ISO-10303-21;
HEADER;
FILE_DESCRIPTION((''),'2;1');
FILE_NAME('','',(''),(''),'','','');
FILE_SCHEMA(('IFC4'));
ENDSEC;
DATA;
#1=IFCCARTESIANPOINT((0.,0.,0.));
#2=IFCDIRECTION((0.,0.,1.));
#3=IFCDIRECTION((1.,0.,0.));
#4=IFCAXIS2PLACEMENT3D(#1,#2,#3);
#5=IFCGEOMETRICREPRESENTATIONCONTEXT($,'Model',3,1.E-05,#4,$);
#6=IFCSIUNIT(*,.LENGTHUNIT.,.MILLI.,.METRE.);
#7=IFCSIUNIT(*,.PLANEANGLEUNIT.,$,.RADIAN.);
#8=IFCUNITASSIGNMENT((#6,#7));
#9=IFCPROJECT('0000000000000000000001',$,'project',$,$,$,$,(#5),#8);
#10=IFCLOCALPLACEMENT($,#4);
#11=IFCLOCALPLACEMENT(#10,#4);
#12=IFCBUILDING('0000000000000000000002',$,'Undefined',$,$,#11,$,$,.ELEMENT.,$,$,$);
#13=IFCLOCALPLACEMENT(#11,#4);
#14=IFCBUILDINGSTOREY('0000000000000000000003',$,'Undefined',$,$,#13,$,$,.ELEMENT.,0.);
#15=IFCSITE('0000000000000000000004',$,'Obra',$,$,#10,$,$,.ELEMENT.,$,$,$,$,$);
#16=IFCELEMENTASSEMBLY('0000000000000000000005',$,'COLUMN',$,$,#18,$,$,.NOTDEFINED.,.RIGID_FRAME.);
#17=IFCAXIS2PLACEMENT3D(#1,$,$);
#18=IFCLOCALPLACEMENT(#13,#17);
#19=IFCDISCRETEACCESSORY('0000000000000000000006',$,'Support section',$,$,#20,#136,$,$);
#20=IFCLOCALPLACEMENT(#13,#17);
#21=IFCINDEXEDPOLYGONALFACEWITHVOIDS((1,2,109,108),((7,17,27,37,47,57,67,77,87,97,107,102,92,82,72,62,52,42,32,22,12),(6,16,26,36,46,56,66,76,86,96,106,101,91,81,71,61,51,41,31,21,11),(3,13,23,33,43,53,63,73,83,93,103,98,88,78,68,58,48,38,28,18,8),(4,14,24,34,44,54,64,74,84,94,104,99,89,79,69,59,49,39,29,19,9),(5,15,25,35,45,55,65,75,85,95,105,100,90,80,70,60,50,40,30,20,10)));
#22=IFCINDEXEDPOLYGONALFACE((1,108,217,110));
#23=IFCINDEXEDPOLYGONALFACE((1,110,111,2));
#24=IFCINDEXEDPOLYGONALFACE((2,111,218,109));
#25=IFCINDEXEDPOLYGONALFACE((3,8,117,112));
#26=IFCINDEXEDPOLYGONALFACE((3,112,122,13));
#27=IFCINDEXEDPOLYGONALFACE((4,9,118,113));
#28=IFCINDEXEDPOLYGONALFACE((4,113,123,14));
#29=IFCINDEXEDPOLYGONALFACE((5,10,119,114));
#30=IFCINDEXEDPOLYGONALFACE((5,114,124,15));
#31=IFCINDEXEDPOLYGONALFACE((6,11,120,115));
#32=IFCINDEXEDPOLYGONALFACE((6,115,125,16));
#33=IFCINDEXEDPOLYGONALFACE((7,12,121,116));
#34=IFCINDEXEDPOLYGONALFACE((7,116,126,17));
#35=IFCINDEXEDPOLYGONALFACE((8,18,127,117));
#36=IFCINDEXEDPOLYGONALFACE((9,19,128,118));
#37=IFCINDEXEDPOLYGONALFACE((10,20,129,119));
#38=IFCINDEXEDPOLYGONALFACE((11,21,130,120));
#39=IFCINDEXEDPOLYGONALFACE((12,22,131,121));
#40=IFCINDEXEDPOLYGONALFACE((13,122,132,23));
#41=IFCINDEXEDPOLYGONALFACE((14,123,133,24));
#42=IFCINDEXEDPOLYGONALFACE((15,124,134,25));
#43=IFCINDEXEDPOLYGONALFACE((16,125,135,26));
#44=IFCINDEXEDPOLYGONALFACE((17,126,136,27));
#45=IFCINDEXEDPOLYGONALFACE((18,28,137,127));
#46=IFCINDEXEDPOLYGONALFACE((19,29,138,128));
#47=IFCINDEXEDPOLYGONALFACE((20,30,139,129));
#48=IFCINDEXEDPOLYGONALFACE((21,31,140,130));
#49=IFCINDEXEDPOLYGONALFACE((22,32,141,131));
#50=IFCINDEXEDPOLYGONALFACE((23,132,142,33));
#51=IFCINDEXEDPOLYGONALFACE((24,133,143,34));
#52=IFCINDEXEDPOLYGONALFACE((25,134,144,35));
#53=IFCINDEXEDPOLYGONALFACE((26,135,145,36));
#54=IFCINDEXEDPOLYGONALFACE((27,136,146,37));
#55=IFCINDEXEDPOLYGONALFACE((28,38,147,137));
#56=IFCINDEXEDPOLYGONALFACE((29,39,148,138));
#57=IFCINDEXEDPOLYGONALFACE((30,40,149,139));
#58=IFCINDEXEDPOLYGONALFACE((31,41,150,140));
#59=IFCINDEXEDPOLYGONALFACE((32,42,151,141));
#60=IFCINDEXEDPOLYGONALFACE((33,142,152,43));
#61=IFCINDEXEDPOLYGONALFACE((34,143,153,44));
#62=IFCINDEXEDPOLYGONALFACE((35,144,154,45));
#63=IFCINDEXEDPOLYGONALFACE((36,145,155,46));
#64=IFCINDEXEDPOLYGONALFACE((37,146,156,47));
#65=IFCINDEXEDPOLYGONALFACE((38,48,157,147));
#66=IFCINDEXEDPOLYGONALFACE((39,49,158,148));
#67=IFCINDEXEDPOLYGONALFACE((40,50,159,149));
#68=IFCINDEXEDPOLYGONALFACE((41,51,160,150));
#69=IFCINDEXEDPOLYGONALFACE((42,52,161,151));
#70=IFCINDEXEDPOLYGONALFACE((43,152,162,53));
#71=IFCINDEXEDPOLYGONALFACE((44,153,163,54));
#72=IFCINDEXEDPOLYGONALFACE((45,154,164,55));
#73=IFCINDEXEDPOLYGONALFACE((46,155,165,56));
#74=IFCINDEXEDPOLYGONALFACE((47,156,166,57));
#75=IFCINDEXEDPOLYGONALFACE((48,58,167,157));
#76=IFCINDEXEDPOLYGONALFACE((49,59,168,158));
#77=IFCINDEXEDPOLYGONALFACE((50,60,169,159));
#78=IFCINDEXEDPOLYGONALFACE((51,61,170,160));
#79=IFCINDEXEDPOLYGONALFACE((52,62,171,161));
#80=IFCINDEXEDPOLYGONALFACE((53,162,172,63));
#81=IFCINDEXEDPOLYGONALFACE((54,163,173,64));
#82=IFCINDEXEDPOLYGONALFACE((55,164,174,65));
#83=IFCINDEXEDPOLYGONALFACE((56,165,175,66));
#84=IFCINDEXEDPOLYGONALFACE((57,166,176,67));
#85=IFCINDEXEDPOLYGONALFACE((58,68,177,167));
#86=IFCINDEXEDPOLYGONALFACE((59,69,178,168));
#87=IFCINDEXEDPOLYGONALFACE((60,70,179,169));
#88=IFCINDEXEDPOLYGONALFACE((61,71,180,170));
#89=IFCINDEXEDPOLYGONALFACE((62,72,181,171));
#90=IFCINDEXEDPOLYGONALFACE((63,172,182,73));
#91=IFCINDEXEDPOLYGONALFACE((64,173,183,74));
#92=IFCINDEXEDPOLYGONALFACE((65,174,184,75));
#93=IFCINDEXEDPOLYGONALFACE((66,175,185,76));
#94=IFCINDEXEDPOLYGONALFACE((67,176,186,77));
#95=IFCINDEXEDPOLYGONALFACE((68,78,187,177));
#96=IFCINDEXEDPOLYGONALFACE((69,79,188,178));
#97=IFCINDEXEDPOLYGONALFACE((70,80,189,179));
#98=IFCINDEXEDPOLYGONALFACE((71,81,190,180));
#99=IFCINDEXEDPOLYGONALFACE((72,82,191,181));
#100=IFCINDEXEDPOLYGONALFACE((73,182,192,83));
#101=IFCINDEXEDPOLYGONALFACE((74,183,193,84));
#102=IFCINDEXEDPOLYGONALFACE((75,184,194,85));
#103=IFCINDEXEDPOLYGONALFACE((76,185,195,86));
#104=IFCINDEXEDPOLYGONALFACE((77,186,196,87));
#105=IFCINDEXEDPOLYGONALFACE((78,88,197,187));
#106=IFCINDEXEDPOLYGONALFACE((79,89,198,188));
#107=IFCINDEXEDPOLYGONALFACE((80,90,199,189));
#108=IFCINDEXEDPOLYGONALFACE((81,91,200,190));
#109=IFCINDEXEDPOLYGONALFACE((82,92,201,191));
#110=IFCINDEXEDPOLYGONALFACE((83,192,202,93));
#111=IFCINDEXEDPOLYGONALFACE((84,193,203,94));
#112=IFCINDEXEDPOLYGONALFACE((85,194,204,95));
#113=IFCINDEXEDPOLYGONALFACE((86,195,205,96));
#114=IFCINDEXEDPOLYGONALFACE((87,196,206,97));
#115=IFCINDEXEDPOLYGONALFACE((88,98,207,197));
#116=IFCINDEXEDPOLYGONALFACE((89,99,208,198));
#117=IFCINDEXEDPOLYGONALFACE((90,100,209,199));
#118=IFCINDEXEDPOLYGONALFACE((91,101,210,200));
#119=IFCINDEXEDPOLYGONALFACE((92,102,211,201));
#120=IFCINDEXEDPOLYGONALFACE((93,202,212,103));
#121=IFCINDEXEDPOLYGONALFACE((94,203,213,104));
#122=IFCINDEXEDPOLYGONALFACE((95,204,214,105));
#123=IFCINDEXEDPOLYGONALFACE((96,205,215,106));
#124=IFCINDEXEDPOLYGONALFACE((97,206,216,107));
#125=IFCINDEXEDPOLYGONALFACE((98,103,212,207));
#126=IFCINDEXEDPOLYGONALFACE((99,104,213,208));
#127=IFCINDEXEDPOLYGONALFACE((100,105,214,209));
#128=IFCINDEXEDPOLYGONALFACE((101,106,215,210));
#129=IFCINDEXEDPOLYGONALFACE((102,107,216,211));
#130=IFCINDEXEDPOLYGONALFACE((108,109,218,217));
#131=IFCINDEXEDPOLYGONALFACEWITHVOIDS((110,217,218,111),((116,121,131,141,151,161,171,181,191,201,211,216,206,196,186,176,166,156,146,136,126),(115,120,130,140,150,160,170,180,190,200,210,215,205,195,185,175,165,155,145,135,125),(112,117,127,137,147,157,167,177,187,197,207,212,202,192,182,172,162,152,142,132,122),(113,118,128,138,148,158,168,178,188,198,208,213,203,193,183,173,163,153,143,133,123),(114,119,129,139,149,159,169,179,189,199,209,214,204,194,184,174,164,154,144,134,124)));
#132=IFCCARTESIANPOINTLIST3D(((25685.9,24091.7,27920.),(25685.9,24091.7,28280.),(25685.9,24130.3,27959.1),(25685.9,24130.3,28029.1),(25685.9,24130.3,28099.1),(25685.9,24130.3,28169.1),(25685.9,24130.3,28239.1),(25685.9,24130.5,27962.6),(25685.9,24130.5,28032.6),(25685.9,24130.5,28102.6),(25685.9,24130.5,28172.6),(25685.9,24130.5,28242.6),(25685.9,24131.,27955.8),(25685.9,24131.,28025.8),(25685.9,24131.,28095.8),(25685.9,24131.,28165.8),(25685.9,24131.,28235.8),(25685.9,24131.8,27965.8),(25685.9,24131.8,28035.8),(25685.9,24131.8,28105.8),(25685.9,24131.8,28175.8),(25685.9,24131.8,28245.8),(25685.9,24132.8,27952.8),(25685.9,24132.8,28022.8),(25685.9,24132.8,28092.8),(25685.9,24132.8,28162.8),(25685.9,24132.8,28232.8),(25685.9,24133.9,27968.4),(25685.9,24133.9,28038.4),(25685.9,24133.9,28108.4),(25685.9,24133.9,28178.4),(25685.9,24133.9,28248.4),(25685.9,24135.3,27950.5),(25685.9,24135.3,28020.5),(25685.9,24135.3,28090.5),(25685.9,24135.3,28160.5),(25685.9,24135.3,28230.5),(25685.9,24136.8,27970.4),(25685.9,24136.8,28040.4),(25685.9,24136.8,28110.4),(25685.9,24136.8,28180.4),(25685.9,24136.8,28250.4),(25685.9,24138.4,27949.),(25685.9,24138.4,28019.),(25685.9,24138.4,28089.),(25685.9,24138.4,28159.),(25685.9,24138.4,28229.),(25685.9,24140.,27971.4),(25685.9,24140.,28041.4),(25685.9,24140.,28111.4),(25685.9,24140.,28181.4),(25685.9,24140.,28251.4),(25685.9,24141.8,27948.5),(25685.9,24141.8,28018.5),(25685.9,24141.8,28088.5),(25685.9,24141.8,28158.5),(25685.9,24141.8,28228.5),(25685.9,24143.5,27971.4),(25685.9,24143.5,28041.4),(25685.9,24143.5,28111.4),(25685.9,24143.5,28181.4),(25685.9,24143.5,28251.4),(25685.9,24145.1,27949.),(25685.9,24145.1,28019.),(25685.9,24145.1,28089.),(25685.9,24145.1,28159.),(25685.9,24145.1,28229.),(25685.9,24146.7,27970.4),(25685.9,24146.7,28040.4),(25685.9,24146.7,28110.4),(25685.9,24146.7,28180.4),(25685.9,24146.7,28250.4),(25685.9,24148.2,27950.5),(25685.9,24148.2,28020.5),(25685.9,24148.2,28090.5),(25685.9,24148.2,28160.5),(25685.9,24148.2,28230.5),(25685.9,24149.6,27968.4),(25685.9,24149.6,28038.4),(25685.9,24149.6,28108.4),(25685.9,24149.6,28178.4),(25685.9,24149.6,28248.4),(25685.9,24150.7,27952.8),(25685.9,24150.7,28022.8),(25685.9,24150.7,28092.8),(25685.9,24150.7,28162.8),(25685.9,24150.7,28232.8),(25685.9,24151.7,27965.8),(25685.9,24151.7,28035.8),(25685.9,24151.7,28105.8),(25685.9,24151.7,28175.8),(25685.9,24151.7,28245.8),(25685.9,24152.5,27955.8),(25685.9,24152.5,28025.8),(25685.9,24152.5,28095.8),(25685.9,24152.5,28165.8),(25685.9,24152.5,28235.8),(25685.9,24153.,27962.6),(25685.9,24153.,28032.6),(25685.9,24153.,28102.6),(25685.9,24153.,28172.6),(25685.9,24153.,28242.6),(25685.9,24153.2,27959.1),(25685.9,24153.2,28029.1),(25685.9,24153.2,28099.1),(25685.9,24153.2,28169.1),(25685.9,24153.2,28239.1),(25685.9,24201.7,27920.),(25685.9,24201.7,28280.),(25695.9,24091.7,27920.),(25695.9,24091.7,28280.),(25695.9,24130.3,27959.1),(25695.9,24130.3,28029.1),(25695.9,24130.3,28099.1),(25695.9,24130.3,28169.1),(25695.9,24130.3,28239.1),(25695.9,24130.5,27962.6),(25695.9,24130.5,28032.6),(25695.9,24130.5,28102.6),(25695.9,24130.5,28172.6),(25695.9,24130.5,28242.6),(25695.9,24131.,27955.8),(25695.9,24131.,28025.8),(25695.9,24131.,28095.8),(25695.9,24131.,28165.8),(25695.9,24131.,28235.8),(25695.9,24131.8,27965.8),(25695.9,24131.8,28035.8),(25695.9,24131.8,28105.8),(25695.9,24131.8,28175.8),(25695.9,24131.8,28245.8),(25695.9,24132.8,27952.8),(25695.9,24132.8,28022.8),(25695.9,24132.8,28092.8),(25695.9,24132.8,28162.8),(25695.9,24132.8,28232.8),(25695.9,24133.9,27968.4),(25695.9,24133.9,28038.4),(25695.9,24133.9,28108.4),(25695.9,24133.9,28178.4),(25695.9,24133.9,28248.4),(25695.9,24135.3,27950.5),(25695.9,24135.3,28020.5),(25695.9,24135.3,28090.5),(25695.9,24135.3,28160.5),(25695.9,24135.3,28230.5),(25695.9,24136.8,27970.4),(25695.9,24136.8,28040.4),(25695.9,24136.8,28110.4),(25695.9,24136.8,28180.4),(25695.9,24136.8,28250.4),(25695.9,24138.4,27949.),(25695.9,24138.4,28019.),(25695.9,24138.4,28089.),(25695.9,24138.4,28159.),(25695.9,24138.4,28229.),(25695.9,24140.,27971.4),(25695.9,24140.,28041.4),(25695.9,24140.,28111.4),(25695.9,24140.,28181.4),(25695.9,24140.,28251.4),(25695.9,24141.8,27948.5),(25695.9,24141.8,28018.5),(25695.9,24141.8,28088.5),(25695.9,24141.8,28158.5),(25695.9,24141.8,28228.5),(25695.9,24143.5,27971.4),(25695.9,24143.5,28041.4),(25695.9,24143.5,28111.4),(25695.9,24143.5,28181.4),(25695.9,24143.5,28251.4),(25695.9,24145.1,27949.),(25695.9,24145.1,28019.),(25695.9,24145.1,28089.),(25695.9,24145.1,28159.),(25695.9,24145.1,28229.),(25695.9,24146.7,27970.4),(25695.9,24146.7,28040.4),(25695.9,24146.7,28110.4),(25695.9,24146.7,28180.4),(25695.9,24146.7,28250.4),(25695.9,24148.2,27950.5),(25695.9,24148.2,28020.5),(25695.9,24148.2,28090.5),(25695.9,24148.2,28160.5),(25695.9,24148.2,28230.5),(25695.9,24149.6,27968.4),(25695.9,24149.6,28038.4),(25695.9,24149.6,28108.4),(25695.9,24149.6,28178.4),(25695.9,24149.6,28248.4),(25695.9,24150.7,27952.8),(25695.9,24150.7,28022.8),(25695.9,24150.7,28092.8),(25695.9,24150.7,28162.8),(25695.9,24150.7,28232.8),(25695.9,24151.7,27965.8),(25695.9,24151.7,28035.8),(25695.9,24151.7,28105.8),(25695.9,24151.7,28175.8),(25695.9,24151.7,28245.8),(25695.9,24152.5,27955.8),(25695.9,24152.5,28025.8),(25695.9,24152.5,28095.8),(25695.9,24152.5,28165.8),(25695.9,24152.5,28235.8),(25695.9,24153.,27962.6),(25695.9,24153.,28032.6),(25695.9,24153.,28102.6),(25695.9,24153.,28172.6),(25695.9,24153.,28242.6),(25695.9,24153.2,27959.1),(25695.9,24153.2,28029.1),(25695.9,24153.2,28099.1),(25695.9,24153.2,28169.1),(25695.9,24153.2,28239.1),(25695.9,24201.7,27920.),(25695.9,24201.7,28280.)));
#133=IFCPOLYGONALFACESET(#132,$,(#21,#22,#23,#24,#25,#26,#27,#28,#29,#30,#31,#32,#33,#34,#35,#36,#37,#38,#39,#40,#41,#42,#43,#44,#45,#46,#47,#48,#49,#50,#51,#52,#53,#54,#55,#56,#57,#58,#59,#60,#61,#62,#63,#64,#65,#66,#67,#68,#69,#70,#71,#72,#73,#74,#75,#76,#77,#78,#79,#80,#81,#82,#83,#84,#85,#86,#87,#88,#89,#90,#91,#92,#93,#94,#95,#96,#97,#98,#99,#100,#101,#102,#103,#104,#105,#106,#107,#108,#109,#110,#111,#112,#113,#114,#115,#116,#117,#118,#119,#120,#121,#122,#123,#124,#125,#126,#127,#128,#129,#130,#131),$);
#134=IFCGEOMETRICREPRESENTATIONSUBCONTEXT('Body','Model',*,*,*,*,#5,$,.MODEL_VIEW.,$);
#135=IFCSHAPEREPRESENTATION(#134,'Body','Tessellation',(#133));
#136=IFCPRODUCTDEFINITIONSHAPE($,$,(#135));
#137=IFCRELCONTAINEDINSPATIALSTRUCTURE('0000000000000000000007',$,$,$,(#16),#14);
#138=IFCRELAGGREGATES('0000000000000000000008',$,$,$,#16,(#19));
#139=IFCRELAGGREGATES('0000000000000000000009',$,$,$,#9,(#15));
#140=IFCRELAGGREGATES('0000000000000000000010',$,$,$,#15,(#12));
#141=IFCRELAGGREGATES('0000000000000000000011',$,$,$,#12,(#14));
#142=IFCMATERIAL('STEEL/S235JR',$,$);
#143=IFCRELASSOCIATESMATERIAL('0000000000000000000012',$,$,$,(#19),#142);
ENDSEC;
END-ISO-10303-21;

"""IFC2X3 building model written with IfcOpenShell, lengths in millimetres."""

from ifc_helpers import new_model, si_unit, frame, origin_with_axes, origin_2d_with_axis, place, context, subcontext, project, spatial, rectangle, circle, extrude, source, transform, mapped, material, element, aggregate, save


model = new_model("IFC2X3")

# Units and contexts
model_context = context("Model", 3, precision=1e-05, world=origin_with_axes())
body_context = subcontext(model_context, "Body", "Model", "MODEL_VIEW")
ifc_project = project(units=[si_unit("LENGTHUNIT", "METRE", prefix="MILLI"), si_unit("PLANEANGLEUNIT", "RADIAN")], contexts=[model_context])

# Site, building, storey
site_placement = place(None, origin_with_axes())
site = spatial("IfcSite", under=ifc_project, at=site_placement, Name="Obra", CompositionType="ELEMENT")
building_placement = place(site_placement, origin_with_axes())
building = spatial("IfcBuilding", under=site, at=building_placement, Name="Undefined", CompositionType="ELEMENT")
storey_placement = place(building_placement, origin_with_axes())
storey = spatial("IfcBuildingStorey", under=building, at=storey_placement, Name="Undefined", CompositionType="ELEMENT", Elevation=0.0)

# Shared definitions
ifc_material_1 = material(Name="STEEL/S235JR")

# Element assembly
assembly_1_placement = place(storey_placement, origin_with_axes())
assembly_1 = element("IfcElementAssembly", 1, at=assembly_1_placement, inside=storey, Name="COLUMN", AssemblyPlace="NOTDEFINED", PredefinedType="RIGID_FRAME")
shared_shape_1 = source(origin_with_axes(), body_context, "Body", "SweptSolid", [
    extrude(circle(Radius=11.5, at=origin_2d_with_axis()), frame((0.0, -14.4, 0.0), z_axis=(0.0, 1.0, 0.0), x_axis=(1.0, 0.0, 0.0)), (0.0, 0.0, 1.0), 10.2),
])

# Discrete accessory, opening
discrete_accessory_1_placement = place(assembly_1_placement, frame((25690.9, 24146.7, 27920.0), z_axis=(0.0, 0.0, 1.0), x_axis=(0.0, 1.0, 0.0)))
discrete_accessory_1 = element("IfcDiscreteAccessory", 2, at=discrete_accessory_1_placement, material=ifc_material_1, Name="Support section", context=body_context, shape_type="SweptSolid", body=[
    extrude(rectangle(XDim=10.0, YDim=110.0, at=origin_2d_with_axis()), frame((0.0, 0.0, 360.0), z_axis=(0.0, 0.0, -1.0), x_axis=(0.0, 1.0, 0.0)), (0.0, 0.0, 1.0), 360.0),
])
opening_1_placement = place(assembly_1_placement, frame((25700.2, 24191.8, 28300.0), z_axis=(0.0, -1.0, 0.0), x_axis=(0.0, 0.0, -1.0)))
element("IfcOpeningElement", 3, at=opening_1_placement, cuts=discrete_accessory_1, ObjectType="Opening", context=body_context, shape_type="MappedRepresentation", body=[
    mapped(shared_shape_1, transform((60.0, 0.0, 50.0))),
    mapped(shared_shape_1, transform((130.0, 0.0, 50.0))),
    mapped(shared_shape_1, transform((200.0, 0.0, 50.0))),
    mapped(shared_shape_1, transform((270.0, 0.0, 50.0))),
    mapped(shared_shape_1, transform((340.0, 0.0, 50.0))),
])
aggregate(assembly_1, [discrete_accessory_1])

save(model, "model.ifc")
